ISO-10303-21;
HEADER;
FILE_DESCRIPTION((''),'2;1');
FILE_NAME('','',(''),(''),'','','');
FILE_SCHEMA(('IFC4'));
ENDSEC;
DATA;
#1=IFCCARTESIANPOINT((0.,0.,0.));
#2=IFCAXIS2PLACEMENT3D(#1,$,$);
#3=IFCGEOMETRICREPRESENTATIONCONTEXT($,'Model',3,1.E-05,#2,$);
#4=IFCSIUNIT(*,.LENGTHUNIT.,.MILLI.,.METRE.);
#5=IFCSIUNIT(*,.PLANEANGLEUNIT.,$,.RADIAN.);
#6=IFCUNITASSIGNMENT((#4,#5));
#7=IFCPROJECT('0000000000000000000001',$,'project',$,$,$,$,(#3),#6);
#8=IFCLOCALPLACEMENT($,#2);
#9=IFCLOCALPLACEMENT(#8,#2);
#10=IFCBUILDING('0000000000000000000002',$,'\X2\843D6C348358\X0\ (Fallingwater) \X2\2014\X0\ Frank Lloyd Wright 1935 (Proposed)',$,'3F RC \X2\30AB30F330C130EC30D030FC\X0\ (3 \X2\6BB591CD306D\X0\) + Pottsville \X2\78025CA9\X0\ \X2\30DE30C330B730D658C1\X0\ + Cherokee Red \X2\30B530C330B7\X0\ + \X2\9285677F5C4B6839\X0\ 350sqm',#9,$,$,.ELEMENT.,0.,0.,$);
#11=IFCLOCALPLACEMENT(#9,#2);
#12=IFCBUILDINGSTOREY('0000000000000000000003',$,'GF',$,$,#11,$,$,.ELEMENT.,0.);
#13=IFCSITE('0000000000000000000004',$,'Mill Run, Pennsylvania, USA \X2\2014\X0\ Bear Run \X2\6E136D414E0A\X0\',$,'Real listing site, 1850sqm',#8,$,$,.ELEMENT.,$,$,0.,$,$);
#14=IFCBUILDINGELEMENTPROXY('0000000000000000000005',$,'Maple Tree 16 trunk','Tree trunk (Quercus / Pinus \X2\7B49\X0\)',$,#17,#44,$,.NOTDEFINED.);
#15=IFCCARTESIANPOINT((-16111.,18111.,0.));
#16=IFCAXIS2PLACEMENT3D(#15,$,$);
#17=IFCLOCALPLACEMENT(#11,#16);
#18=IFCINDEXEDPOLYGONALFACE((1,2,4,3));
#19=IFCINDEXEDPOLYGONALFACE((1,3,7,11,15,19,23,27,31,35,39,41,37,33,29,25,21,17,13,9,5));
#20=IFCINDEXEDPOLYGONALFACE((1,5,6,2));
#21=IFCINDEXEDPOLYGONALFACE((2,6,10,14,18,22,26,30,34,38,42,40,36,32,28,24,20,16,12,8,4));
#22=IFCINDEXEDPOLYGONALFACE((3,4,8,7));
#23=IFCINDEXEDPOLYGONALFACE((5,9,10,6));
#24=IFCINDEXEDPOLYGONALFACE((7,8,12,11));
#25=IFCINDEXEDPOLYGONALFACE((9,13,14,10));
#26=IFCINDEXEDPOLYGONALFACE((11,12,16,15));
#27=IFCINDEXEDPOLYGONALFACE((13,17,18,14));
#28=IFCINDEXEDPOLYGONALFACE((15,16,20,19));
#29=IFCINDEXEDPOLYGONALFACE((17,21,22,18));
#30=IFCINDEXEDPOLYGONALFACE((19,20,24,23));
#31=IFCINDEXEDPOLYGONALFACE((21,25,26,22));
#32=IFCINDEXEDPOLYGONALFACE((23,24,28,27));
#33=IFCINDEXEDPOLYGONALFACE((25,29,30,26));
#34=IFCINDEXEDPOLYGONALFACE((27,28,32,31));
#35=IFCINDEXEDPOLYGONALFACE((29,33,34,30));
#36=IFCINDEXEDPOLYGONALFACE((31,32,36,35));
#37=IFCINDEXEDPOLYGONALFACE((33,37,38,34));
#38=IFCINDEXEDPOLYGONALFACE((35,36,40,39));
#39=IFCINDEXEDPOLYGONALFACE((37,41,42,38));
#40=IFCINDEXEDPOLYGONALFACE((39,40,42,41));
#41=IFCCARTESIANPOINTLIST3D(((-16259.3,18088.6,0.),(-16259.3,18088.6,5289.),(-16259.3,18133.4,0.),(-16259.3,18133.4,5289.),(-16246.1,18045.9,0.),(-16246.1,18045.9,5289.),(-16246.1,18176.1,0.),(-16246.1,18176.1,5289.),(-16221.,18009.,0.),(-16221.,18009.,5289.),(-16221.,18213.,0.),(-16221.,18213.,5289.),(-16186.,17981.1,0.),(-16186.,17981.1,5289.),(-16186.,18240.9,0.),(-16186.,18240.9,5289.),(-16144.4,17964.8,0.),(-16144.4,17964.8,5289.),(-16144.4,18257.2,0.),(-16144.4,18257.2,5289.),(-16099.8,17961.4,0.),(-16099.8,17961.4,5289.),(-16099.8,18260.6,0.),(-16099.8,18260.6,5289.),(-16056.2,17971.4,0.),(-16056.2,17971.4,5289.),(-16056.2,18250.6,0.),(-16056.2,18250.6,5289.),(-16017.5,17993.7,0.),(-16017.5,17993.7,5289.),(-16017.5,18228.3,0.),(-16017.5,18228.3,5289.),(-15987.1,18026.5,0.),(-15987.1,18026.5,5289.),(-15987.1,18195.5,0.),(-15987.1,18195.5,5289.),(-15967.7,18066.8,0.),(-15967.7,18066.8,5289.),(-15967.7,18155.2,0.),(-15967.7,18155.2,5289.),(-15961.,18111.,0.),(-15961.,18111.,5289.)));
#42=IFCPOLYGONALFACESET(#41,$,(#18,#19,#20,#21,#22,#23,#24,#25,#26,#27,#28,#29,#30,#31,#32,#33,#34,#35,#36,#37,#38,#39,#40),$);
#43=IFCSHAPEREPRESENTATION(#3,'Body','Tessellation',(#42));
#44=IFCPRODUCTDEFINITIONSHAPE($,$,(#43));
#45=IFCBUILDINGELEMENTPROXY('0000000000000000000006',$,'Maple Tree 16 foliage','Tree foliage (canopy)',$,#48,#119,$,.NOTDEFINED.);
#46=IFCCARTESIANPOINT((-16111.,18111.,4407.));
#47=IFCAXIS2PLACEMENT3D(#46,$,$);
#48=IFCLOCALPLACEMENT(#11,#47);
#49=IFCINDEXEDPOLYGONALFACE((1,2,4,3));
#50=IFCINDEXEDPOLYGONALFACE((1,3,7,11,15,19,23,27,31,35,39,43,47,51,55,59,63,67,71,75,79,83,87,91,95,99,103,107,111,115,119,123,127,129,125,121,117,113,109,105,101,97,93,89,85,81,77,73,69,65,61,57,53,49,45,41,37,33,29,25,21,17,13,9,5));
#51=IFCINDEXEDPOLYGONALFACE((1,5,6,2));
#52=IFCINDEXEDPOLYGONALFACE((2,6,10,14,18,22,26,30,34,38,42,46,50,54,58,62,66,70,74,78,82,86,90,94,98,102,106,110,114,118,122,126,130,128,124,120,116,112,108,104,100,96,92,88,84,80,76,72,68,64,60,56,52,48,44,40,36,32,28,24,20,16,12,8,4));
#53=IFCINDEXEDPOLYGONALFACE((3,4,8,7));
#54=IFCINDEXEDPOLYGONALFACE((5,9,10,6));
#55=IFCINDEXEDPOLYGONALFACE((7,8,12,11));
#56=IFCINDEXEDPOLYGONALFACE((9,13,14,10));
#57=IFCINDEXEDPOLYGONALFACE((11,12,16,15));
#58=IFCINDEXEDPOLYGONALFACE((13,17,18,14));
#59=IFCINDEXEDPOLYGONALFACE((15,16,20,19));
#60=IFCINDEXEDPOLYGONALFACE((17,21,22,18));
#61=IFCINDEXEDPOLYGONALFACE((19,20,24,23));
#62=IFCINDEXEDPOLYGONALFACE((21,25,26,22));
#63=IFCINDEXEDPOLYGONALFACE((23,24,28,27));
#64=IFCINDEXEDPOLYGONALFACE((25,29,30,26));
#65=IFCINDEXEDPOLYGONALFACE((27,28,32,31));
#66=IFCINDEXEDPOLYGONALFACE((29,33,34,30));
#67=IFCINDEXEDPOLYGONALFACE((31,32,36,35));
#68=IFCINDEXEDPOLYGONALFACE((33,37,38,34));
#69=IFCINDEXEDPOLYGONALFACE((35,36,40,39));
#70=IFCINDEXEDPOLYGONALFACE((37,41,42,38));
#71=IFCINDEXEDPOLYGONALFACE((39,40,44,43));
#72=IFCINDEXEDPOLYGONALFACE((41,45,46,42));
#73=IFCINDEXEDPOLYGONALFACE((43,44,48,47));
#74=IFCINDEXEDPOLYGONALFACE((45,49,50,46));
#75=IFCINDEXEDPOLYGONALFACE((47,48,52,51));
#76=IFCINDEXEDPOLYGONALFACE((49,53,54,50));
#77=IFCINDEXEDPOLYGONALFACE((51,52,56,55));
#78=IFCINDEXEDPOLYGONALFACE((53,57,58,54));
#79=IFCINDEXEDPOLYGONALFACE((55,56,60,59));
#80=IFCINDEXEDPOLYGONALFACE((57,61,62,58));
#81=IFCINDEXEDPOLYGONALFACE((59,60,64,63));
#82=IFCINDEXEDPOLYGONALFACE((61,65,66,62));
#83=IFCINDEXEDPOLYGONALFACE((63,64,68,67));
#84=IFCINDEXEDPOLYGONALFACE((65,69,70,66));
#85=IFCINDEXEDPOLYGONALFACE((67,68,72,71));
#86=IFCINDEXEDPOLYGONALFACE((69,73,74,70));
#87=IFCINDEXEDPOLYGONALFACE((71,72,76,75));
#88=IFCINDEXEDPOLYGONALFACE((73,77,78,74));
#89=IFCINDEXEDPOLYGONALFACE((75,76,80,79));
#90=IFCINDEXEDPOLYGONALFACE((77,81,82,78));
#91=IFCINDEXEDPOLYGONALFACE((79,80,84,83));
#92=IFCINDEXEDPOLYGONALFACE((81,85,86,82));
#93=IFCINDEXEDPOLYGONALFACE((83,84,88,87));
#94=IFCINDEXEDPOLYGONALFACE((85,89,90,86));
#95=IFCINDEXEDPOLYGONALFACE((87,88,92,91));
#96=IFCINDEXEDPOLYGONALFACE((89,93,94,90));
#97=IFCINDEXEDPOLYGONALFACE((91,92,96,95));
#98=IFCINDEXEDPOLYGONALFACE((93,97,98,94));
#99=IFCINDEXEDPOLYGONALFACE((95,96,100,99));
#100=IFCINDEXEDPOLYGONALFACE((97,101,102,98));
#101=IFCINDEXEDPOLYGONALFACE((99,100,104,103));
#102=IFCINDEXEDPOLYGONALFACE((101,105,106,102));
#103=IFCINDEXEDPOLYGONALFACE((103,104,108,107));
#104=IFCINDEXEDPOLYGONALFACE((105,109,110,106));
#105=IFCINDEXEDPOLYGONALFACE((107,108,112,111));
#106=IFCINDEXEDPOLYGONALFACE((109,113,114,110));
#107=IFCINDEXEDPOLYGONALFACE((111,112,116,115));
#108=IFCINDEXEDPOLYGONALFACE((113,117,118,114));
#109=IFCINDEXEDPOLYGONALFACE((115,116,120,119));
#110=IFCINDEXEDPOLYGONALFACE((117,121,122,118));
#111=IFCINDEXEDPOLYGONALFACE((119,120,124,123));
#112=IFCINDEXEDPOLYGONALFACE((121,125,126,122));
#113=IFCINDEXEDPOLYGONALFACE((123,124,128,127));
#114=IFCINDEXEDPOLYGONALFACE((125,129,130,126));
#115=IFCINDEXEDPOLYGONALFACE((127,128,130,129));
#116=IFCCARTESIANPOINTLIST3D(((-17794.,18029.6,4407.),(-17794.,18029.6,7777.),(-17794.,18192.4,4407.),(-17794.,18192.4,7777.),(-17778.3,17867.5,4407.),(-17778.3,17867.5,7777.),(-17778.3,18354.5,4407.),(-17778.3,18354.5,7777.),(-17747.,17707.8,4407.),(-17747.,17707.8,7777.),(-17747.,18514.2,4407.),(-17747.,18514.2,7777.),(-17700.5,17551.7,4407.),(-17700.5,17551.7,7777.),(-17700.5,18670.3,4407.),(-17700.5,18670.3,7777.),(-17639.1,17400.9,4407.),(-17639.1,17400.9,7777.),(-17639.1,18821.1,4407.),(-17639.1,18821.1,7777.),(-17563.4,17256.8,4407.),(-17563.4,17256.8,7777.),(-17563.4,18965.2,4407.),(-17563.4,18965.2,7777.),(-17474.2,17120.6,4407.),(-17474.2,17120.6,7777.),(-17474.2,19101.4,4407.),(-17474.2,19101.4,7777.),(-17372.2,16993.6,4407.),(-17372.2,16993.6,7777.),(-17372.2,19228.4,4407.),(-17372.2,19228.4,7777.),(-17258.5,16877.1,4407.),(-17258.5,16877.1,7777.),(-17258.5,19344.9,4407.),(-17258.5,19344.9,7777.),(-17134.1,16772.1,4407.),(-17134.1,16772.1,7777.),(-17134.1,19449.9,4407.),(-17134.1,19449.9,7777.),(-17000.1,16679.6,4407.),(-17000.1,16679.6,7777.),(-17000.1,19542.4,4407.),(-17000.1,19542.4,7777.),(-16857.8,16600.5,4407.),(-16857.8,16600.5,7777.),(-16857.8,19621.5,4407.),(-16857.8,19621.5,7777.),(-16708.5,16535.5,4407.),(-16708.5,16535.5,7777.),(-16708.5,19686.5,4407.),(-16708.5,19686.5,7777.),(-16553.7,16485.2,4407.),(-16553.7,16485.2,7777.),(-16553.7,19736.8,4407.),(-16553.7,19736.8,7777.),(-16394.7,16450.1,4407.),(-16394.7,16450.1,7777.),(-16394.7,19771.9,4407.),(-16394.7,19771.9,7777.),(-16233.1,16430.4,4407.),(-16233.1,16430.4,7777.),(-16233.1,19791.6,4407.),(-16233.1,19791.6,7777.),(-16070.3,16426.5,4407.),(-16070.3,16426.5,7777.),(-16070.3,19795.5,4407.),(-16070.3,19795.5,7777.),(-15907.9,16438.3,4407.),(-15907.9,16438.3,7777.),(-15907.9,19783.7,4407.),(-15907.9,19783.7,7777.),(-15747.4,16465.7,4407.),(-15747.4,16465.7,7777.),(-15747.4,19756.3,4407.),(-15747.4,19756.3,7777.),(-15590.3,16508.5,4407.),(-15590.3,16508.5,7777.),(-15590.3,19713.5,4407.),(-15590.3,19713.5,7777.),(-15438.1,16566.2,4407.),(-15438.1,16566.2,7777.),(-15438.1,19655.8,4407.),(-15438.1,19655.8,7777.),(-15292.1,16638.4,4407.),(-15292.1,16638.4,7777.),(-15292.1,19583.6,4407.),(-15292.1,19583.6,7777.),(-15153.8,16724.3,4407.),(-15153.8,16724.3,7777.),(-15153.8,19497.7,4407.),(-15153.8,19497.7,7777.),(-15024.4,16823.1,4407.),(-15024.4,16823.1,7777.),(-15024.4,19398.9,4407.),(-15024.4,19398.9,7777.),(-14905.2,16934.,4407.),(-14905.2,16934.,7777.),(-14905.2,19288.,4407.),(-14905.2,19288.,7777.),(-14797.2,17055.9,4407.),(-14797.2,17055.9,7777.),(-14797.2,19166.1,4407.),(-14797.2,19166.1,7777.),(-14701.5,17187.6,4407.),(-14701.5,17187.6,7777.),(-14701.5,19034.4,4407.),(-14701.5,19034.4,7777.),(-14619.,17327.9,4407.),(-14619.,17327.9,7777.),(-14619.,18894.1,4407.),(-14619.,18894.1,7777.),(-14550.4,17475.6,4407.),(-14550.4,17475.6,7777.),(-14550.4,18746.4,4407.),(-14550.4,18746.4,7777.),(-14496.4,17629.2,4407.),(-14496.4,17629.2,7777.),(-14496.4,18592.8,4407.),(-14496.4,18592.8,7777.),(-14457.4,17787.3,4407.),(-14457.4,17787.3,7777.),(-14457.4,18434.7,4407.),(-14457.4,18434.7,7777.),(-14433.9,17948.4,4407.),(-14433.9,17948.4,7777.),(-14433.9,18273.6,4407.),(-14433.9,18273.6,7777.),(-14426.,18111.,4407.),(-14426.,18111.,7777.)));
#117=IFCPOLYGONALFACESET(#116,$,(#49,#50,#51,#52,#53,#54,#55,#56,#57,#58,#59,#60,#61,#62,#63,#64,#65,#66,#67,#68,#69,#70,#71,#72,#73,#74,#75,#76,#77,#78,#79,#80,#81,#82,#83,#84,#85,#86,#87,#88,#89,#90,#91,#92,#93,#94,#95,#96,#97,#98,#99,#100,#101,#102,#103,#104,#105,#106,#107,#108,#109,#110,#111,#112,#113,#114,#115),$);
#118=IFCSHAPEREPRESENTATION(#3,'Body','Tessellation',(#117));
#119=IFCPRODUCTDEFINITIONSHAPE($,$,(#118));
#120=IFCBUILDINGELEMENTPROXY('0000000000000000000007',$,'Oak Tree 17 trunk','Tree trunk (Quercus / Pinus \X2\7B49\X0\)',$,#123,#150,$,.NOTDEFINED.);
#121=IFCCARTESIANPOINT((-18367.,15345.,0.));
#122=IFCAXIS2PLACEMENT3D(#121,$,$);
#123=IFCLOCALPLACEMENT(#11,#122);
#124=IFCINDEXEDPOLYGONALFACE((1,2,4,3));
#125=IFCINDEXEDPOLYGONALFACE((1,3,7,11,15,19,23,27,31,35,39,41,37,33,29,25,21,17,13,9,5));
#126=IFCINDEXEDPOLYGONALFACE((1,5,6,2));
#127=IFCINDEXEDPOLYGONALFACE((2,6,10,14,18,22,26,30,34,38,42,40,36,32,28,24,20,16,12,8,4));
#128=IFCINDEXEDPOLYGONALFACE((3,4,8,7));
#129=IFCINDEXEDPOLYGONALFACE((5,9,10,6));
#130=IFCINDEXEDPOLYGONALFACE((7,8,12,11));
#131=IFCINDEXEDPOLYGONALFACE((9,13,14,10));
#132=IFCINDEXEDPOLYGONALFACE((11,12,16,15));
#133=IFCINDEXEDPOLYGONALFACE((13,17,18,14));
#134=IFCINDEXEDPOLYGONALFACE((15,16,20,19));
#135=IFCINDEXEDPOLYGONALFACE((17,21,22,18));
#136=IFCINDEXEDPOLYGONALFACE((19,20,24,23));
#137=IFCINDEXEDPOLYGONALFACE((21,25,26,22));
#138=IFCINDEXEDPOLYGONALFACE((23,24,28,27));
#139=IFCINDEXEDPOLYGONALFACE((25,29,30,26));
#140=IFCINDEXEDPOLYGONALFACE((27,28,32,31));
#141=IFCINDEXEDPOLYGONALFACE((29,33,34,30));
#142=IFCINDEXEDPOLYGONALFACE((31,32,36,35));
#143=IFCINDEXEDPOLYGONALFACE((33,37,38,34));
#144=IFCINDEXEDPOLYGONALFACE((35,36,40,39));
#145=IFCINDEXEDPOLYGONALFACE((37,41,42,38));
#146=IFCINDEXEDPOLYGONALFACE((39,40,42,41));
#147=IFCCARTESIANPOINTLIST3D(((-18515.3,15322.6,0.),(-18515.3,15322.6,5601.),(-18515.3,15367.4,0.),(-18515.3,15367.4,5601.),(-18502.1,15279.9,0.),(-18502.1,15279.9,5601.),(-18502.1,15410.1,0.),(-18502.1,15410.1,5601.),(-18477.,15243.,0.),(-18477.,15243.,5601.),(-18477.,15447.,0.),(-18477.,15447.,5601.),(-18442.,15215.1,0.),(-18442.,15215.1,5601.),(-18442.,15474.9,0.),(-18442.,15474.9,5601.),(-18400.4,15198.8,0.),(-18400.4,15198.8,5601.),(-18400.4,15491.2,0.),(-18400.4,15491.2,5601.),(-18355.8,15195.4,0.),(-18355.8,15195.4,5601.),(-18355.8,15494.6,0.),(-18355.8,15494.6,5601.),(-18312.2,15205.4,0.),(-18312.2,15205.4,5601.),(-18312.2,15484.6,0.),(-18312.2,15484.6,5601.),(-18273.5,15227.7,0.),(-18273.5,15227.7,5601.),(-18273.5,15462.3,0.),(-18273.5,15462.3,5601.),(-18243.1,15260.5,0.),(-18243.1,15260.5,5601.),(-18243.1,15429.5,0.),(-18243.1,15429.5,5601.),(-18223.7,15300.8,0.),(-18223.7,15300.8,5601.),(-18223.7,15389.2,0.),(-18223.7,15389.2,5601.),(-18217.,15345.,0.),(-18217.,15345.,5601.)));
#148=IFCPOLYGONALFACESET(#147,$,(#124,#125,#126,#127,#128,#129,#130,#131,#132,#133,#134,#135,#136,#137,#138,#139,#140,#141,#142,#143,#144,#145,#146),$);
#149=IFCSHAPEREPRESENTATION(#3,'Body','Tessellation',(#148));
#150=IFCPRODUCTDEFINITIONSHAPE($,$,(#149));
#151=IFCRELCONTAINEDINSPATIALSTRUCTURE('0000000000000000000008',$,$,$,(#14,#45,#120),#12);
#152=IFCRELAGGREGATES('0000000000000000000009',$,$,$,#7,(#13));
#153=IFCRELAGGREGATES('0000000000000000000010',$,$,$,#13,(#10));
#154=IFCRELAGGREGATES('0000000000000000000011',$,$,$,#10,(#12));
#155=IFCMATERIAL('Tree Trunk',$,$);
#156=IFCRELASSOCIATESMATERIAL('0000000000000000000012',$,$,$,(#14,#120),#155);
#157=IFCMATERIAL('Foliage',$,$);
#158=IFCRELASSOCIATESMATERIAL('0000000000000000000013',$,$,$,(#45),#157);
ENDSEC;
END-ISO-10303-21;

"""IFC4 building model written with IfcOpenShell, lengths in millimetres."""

from ifc_helpers import new_model, si_unit, frame, origin, origin_2d, place, context, project, spatial, circle, extrude, material, element, save


model = new_model("IFC4")

# Units and contexts
model_context = context("Model", 3, precision=1e-05, world=origin())
ifc_project = project(units=[si_unit("LENGTHUNIT", "METRE", prefix="MILLI"), si_unit("PLANEANGLEUNIT", "RADIAN")], contexts=[model_context])

# Site, building, storey
site_placement = place(None, origin())
site = spatial("IfcSite", under=ifc_project, at=site_placement, Name="Mill Run, Pennsylvania, USA — Bear Run 渓流上", ObjectType="Real listing site, 1850sqm", CompositionType="ELEMENT", RefElevation=0.0)
building_placement = place(site_placement, origin())
building = spatial("IfcBuilding", under=site, at=building_placement, Name="落水荘 (Fallingwater) — Frank Lloyd Wright 1935 (Proposed)", ObjectType="3F RC カンチレバー (3 段重ね) + Pottsville 砂岩 マッシブ壁 + Cherokee Red サッシ + 銅板屋根 350sqm", CompositionType="ELEMENT", ElevationOfRefHeight=0.0, ElevationOfTerrain=0.0)
storey_placement = place(building_placement, origin())
storey = spatial("IfcBuildingStorey", under=building, at=storey_placement, Name="GF", CompositionType="ELEMENT", Elevation=0.0)

# Building element proxies
ifc_material_1 = material(Name="Tree Trunk")
ifc_material_2 = material(Name="Foliage")
proxy_1_placement = place(storey_placement, frame((-16111.0, 18111.0, 0.0)))
element("IfcBuildingElementProxy", 1, at=proxy_1_placement, inside=storey, material=ifc_material_1, Name="Maple Tree 16 trunk", Description="Tree trunk (Quercus / Pinus 等)", PredefinedType="NOTDEFINED", context=model_context, shape_type="SweptSolid", body=[
    extrude(circle(Radius=150.0, at=origin_2d()), frame((-16111.0, 18111.0, 0.0)), (0.0, 0.0, 1.0), 5289.0),
])
proxy_2_placement = place(storey_placement, frame((-16111.0, 18111.0, 4407.0)))
element("IfcBuildingElementProxy", 2, at=proxy_2_placement, inside=storey, material=ifc_material_2, Name="Maple Tree 16 foliage", Description="Tree foliage (canopy)", PredefinedType="NOTDEFINED", context=model_context, shape_type="SweptSolid", body=[
    extrude(circle(Radius=1685.0, at=origin_2d()), frame((-16111.0, 18111.0, 4407.0)), (0.0, 0.0, 1.0), 3370.0),
])
proxy_3_placement = place(storey_placement, frame((-18367.0, 15345.0, 0.0)))
element("IfcBuildingElementProxy", 3, at=proxy_3_placement, inside=storey, material=ifc_material_1, Name="Oak Tree 17 trunk", Description="Tree trunk (Quercus / Pinus 等)", PredefinedType="NOTDEFINED", context=model_context, shape_type="SweptSolid", body=[
    extrude(circle(Radius=150.0, at=origin_2d()), frame((-18367.0, 15345.0, 0.0)), (0.0, 0.0, 1.0), 5601.0),
])

save(model, "model.ifc")
